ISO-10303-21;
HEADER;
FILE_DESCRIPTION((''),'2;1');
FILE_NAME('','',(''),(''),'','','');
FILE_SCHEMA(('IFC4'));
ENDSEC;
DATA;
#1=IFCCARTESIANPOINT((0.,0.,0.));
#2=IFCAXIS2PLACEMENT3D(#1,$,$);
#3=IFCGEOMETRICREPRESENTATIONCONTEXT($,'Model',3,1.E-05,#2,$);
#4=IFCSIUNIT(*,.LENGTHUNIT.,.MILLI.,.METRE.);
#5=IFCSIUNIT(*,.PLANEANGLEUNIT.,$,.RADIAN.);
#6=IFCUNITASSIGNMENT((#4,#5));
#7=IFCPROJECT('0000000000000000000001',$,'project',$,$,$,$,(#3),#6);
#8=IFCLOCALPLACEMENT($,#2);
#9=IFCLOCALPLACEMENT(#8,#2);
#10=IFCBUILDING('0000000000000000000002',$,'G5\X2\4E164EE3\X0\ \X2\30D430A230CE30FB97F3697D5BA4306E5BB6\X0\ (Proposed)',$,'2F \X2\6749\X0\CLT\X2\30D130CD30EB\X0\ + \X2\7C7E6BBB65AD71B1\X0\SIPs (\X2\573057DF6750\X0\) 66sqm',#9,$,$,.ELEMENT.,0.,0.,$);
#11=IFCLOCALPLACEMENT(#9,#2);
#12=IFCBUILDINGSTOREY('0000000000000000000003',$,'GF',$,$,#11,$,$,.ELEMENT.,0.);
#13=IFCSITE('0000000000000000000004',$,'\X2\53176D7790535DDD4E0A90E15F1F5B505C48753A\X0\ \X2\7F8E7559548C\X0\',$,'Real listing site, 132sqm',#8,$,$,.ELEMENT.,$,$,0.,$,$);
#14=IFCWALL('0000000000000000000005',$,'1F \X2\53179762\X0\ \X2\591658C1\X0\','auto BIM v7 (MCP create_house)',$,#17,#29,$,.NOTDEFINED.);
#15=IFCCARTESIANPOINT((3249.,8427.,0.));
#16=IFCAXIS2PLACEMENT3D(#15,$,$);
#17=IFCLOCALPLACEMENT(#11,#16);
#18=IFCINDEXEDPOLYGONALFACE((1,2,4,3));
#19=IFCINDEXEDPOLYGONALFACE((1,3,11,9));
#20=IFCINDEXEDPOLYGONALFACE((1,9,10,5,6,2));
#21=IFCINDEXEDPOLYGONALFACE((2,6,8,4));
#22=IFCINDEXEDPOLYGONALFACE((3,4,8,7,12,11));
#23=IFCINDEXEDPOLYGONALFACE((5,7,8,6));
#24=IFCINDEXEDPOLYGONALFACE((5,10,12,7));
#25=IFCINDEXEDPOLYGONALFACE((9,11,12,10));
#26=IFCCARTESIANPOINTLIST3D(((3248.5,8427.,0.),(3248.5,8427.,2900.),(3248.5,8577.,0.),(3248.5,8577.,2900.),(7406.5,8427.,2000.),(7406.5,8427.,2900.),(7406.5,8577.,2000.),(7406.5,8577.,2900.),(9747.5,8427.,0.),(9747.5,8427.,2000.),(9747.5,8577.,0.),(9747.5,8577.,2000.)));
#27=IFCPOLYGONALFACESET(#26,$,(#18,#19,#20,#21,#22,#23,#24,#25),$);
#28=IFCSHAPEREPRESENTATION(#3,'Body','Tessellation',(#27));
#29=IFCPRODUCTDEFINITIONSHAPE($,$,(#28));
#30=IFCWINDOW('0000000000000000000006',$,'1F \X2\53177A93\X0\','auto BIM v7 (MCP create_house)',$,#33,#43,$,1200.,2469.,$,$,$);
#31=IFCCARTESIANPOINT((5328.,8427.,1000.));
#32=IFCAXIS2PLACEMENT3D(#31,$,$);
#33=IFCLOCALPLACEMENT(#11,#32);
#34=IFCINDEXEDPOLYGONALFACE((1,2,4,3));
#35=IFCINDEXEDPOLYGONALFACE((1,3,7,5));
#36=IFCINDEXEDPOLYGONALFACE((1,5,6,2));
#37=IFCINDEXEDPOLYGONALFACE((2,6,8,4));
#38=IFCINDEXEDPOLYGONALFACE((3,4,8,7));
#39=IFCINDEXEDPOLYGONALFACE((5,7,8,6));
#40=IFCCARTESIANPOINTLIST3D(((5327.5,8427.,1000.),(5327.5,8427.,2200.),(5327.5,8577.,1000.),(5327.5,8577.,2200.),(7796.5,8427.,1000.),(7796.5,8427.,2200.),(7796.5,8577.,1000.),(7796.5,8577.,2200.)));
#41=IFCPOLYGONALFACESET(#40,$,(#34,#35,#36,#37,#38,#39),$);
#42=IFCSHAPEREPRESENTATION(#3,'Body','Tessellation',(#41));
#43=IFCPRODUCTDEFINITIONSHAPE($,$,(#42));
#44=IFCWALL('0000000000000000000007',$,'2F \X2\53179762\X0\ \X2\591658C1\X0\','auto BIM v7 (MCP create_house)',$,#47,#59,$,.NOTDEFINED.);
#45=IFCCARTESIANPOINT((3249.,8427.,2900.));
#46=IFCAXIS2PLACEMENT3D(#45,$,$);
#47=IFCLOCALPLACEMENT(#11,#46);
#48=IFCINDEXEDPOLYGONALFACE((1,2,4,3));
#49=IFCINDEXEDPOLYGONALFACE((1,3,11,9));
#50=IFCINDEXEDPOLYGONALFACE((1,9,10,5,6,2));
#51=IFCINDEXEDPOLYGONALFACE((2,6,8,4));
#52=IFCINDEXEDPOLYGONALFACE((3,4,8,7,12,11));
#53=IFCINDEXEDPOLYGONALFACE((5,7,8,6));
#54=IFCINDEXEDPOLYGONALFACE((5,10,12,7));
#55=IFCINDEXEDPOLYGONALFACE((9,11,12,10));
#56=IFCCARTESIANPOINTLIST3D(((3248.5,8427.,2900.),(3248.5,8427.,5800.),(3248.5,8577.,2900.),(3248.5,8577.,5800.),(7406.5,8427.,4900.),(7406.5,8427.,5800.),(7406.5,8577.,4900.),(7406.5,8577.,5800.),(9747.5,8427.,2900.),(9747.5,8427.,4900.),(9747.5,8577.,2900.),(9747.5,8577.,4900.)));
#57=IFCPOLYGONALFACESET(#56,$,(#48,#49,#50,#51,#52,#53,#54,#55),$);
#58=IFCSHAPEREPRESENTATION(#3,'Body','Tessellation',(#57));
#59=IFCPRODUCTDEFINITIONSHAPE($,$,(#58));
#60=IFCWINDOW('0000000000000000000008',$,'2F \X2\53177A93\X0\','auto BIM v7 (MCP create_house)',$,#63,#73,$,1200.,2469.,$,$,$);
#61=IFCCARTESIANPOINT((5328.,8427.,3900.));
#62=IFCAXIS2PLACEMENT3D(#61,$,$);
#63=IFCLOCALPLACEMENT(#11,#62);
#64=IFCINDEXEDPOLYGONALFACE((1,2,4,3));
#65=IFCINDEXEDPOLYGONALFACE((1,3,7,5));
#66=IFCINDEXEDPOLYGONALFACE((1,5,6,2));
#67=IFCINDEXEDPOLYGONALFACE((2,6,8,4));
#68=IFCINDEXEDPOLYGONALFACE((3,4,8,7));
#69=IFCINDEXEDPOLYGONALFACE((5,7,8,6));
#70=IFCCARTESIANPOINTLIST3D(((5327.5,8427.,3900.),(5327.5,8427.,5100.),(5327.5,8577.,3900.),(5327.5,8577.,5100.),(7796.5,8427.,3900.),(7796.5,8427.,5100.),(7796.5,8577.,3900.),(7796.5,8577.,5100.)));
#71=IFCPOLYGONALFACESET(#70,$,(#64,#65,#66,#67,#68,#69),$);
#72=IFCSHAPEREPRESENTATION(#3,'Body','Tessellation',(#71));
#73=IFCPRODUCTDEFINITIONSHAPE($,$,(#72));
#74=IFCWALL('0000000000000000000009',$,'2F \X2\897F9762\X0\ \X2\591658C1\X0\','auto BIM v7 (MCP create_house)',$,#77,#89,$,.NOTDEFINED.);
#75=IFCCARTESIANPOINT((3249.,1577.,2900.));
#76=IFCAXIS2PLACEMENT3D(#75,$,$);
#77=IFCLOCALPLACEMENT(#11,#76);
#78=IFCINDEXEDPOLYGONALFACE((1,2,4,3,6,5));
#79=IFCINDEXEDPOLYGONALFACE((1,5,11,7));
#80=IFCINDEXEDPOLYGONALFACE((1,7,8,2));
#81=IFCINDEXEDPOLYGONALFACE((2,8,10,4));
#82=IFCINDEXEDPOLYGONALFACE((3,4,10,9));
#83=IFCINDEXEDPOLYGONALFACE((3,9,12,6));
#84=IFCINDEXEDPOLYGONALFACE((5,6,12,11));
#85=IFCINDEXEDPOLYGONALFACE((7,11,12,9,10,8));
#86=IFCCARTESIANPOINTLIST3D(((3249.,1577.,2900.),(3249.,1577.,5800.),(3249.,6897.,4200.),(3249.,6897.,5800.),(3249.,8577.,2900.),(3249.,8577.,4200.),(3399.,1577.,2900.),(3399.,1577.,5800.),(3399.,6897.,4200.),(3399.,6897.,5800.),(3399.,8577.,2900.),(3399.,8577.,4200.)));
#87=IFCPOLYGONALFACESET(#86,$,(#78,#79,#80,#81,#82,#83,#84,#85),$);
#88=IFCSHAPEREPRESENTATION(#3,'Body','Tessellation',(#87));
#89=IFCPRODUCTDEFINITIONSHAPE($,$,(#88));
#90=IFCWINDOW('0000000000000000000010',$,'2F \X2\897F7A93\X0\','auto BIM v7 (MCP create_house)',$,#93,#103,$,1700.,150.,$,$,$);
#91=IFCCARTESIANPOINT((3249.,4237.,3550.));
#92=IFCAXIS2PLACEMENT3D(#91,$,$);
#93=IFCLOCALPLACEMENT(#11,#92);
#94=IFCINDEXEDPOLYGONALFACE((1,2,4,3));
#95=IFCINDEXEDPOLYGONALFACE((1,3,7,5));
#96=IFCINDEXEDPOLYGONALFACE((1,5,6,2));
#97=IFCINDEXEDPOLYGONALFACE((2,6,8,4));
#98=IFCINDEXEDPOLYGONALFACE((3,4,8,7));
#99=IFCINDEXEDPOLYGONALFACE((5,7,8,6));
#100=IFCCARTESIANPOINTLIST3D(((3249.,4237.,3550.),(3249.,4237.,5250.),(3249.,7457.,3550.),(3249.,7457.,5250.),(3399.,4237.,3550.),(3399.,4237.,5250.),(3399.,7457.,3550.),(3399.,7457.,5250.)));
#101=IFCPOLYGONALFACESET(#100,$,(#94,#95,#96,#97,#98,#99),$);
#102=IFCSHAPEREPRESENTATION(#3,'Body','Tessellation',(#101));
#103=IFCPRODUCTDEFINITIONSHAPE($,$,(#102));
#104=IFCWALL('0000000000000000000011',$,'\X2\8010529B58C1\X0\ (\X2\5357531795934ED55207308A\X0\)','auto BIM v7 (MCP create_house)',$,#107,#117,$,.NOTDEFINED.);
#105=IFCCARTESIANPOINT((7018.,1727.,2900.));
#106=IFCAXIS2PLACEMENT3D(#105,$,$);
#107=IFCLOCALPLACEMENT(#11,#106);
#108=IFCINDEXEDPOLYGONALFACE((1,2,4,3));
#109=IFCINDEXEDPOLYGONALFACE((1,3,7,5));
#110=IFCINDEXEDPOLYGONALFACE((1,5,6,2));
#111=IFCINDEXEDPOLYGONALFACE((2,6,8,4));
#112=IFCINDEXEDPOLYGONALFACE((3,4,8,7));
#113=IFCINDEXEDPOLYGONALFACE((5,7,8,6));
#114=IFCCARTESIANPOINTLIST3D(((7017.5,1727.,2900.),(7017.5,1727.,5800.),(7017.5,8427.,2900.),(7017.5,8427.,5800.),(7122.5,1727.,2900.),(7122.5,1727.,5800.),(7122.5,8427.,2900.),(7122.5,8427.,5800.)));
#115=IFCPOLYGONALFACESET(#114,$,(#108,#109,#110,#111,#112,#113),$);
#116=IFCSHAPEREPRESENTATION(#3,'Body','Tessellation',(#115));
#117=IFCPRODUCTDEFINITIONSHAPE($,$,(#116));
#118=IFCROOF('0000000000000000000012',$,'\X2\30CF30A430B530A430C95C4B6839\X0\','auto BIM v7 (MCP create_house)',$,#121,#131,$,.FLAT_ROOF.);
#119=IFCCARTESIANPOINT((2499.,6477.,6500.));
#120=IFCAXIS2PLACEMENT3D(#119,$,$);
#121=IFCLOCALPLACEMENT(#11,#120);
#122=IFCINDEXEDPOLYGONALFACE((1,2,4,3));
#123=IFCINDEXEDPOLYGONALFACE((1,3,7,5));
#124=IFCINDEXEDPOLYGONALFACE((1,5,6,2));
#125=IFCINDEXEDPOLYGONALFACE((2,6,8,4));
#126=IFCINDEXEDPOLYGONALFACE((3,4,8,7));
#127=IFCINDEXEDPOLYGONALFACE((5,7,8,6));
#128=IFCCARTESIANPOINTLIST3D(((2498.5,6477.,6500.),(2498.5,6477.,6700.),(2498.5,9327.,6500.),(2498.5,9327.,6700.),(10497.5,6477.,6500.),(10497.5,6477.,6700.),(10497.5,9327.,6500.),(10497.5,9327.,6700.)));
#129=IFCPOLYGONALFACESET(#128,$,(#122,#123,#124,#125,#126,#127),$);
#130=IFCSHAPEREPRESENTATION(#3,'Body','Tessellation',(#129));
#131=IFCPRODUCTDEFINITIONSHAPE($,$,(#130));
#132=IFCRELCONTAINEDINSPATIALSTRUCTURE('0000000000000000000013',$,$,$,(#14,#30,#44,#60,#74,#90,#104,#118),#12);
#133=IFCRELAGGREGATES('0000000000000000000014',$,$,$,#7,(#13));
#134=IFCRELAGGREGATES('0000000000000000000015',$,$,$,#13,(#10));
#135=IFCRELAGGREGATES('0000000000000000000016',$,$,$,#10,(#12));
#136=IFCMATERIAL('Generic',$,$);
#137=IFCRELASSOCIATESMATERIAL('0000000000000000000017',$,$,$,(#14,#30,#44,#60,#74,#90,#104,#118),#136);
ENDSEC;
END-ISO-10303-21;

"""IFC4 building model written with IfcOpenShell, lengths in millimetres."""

from ifc_helpers import new_model, si_unit, frame, frame_2d, origin, place, context, project, spatial, rectangle, extrude, material, element, fill, save


model = new_model("IFC4")

# Units and contexts
model_context = context("Model", 3, precision=1e-05, world=origin())
ifc_project = project(units=[si_unit("LENGTHUNIT", "METRE", prefix="MILLI"), si_unit("PLANEANGLEUNIT", "RADIAN")], contexts=[model_context])

# Site, building, storey
site_placement = place(None, origin())
site = spatial("IfcSite", under=ifc_project, at=site_placement, Name="北海道川上郡弟子屈町 美留和", ObjectType="Real listing site, 132sqm", CompositionType="ELEMENT", RefElevation=0.0)
building_placement = place(site_placement, origin())
building = spatial("IfcBuilding", under=site, at=building_placement, Name="G5世代 ピアノ・音楽室の家 (Proposed)", ObjectType="2F 杉CLTパネル + 籾殻断熱SIPs (地域材) 66sqm", CompositionType="ELEMENT", ElevationOfRefHeight=0.0, ElevationOfTerrain=0.0)
storey_placement = place(building_placement, origin())
storey = spatial("IfcBuildingStorey", under=building, at=storey_placement, Name="GF", CompositionType="ELEMENT", Elevation=0.0)

# Wall, opening, window
ifc_material = material(Name="Generic")
wall_1_placement = place(storey_placement, frame((3249.0, 8427.0, 0.0)))
wall_1 = element("IfcWall", 1, at=wall_1_placement, inside=storey, material=ifc_material, Name="1F 北面 外壁", Description="auto BIM v7 (MCP create_house)", PredefinedType="NOTDEFINED", context=model_context, shape_type="SweptSolid", body=[
    extrude(rectangle(XDim=6499.0, YDim=150.0, at=frame_2d((3249.0, 75.0))), frame((3249.0, 8427.0, 0.0)), (0.0, 0.0, 1.0), 2900.0),
])
opening_1_placement = place(storey_placement, frame((5328.0, 8427.0, 1000.0)))
opening_1 = element("IfcOpeningElement", 2, at=opening_1_placement, cuts=wall_1, PredefinedType="NOTDEFINED", context=model_context, shape_type="SweptSolid", body=[
    extrude(rectangle(XDim=2469.0, YDim=150.0, at=frame_2d((1234.0, 75.0))), frame((5328.0, 8427.0, 1000.0)), (0.0, 0.0, 1.0), 1200.0),
])
window_1_placement = place(storey_placement, frame((5328.0, 8427.0, 1000.0)))
window_1 = element("IfcWindow", 3, at=window_1_placement, inside=storey, material=ifc_material, Name="1F 北窓", Description="auto BIM v7 (MCP create_house)", OverallHeight=1200.0, OverallWidth=2469.0, context=model_context, shape_type="SweptSolid", body=[
    extrude(rectangle(XDim=2469.0, YDim=150.0, at=frame_2d((1234.0, 75.0))), frame((5328.0, 8427.0, 1000.0)), (0.0, 0.0, 1.0), 1200.0),
])
fill(opening_1, window_1)

# Walls, openings, windows
wall_2_placement = place(storey_placement, frame((3249.0, 8427.0, 2900.0)))
wall_2 = element("IfcWall", 4, at=wall_2_placement, inside=storey, material=ifc_material, Name="2F 北面 外壁", Description="auto BIM v7 (MCP create_house)", PredefinedType="NOTDEFINED", context=model_context, shape_type="SweptSolid", body=[
    extrude(rectangle(XDim=6499.0, YDim=150.0, at=frame_2d((3249.0, 75.0))), frame((3249.0, 8427.0, 2900.0)), (0.0, 0.0, 1.0), 2900.0),
])
opening_2_placement = place(storey_placement, frame((5328.0, 8427.0, 3900.0)))
opening_2 = element("IfcOpeningElement", 5, at=opening_2_placement, cuts=wall_2, PredefinedType="NOTDEFINED", context=model_context, shape_type="SweptSolid", body=[
    extrude(rectangle(XDim=2469.0, YDim=150.0, at=frame_2d((1234.0, 75.0))), frame((5328.0, 8427.0, 3900.0)), (0.0, 0.0, 1.0), 1200.0),
])
window_2_placement = place(storey_placement, frame((5328.0, 8427.0, 3900.0)))
window_2 = element("IfcWindow", 6, at=window_2_placement, inside=storey, material=ifc_material, Name="2F 北窓", Description="auto BIM v7 (MCP create_house)", OverallHeight=1200.0, OverallWidth=2469.0, context=model_context, shape_type="SweptSolid", body=[
    extrude(rectangle(XDim=2469.0, YDim=150.0, at=frame_2d((1234.0, 75.0))), frame((5328.0, 8427.0, 3900.0)), (0.0, 0.0, 1.0), 1200.0),
])
fill(opening_2, window_2)
wall_3_placement = place(storey_placement, frame((3249.0, 1577.0, 2900.0)))
wall_3 = element("IfcWall", 7, at=wall_3_placement, inside=storey, material=ifc_material, Name="2F 西面 外壁", Description="auto BIM v7 (MCP create_house)", PredefinedType="NOTDEFINED", context=model_context, shape_type="SweptSolid", body=[
    extrude(rectangle(XDim=150.0, YDim=7000.0, at=frame_2d((75.0, 3500.0))), frame((3249.0, 1577.0, 2900.0)), (0.0, 0.0, 1.0), 2900.0),
])
opening_3_placement = place(storey_placement, frame((3249.0, 4237.0, 3550.0)))
opening_3 = element("IfcOpeningElement", 8, at=opening_3_placement, cuts=wall_3, PredefinedType="NOTDEFINED", context=model_context, shape_type="SweptSolid", body=[
    extrude(rectangle(XDim=150.0, YDim=3220.0, at=frame_2d((75.0, 1610.0))), frame((3249.0, 4237.0, 3550.0)), (0.0, 0.0, 1.0), 1700.0),
])
window_3_placement = place(storey_placement, frame((3249.0, 4237.0, 3550.0)))
window_3 = element("IfcWindow", 9, at=window_3_placement, inside=storey, material=ifc_material, Name="2F 西窓", Description="auto BIM v7 (MCP create_house)", OverallHeight=1700.0, OverallWidth=150.0, context=model_context, shape_type="SweptSolid", body=[
    extrude(rectangle(XDim=150.0, YDim=3220.0, at=frame_2d((75.0, 1610.0))), frame((3249.0, 4237.0, 3550.0)), (0.0, 0.0, 1.0), 1700.0),
])
fill(opening_3, window_3)

# Wall
wall_4_placement = place(storey_placement, frame((7018.0, 1727.0, 2900.0)))
element("IfcWall", 10, at=wall_4_placement, inside=storey, material=ifc_material, Name="耐力壁 (南北間仕切り)", Description="auto BIM v7 (MCP create_house)", PredefinedType="NOTDEFINED", context=model_context, shape_type="SweptSolid", body=[
    extrude(rectangle(XDim=105.0, YDim=6700.0, at=frame_2d((52.0, 3350.0))), frame((7018.0, 1727.0, 2900.0)), (0.0, 0.0, 1.0), 2900.0),
])

# Roof
roof_placement = place(storey_placement, frame((2499.0, 6477.0, 6500.0)))
element("IfcRoof", 11, at=roof_placement, inside=storey, material=ifc_material, Name="ハイサイド屋根", Description="auto BIM v7 (MCP create_house)", PredefinedType="FLAT_ROOF", context=model_context, shape_type="SweptSolid", body=[
    extrude(rectangle(XDim=7999.0, YDim=2850.0, at=frame_2d((3999.0, 1425.0))), frame((2499.0, 6477.0, 6500.0)), (0.0, 0.0, 1.0), 200.0),
])

save(model, "model.ifc")
